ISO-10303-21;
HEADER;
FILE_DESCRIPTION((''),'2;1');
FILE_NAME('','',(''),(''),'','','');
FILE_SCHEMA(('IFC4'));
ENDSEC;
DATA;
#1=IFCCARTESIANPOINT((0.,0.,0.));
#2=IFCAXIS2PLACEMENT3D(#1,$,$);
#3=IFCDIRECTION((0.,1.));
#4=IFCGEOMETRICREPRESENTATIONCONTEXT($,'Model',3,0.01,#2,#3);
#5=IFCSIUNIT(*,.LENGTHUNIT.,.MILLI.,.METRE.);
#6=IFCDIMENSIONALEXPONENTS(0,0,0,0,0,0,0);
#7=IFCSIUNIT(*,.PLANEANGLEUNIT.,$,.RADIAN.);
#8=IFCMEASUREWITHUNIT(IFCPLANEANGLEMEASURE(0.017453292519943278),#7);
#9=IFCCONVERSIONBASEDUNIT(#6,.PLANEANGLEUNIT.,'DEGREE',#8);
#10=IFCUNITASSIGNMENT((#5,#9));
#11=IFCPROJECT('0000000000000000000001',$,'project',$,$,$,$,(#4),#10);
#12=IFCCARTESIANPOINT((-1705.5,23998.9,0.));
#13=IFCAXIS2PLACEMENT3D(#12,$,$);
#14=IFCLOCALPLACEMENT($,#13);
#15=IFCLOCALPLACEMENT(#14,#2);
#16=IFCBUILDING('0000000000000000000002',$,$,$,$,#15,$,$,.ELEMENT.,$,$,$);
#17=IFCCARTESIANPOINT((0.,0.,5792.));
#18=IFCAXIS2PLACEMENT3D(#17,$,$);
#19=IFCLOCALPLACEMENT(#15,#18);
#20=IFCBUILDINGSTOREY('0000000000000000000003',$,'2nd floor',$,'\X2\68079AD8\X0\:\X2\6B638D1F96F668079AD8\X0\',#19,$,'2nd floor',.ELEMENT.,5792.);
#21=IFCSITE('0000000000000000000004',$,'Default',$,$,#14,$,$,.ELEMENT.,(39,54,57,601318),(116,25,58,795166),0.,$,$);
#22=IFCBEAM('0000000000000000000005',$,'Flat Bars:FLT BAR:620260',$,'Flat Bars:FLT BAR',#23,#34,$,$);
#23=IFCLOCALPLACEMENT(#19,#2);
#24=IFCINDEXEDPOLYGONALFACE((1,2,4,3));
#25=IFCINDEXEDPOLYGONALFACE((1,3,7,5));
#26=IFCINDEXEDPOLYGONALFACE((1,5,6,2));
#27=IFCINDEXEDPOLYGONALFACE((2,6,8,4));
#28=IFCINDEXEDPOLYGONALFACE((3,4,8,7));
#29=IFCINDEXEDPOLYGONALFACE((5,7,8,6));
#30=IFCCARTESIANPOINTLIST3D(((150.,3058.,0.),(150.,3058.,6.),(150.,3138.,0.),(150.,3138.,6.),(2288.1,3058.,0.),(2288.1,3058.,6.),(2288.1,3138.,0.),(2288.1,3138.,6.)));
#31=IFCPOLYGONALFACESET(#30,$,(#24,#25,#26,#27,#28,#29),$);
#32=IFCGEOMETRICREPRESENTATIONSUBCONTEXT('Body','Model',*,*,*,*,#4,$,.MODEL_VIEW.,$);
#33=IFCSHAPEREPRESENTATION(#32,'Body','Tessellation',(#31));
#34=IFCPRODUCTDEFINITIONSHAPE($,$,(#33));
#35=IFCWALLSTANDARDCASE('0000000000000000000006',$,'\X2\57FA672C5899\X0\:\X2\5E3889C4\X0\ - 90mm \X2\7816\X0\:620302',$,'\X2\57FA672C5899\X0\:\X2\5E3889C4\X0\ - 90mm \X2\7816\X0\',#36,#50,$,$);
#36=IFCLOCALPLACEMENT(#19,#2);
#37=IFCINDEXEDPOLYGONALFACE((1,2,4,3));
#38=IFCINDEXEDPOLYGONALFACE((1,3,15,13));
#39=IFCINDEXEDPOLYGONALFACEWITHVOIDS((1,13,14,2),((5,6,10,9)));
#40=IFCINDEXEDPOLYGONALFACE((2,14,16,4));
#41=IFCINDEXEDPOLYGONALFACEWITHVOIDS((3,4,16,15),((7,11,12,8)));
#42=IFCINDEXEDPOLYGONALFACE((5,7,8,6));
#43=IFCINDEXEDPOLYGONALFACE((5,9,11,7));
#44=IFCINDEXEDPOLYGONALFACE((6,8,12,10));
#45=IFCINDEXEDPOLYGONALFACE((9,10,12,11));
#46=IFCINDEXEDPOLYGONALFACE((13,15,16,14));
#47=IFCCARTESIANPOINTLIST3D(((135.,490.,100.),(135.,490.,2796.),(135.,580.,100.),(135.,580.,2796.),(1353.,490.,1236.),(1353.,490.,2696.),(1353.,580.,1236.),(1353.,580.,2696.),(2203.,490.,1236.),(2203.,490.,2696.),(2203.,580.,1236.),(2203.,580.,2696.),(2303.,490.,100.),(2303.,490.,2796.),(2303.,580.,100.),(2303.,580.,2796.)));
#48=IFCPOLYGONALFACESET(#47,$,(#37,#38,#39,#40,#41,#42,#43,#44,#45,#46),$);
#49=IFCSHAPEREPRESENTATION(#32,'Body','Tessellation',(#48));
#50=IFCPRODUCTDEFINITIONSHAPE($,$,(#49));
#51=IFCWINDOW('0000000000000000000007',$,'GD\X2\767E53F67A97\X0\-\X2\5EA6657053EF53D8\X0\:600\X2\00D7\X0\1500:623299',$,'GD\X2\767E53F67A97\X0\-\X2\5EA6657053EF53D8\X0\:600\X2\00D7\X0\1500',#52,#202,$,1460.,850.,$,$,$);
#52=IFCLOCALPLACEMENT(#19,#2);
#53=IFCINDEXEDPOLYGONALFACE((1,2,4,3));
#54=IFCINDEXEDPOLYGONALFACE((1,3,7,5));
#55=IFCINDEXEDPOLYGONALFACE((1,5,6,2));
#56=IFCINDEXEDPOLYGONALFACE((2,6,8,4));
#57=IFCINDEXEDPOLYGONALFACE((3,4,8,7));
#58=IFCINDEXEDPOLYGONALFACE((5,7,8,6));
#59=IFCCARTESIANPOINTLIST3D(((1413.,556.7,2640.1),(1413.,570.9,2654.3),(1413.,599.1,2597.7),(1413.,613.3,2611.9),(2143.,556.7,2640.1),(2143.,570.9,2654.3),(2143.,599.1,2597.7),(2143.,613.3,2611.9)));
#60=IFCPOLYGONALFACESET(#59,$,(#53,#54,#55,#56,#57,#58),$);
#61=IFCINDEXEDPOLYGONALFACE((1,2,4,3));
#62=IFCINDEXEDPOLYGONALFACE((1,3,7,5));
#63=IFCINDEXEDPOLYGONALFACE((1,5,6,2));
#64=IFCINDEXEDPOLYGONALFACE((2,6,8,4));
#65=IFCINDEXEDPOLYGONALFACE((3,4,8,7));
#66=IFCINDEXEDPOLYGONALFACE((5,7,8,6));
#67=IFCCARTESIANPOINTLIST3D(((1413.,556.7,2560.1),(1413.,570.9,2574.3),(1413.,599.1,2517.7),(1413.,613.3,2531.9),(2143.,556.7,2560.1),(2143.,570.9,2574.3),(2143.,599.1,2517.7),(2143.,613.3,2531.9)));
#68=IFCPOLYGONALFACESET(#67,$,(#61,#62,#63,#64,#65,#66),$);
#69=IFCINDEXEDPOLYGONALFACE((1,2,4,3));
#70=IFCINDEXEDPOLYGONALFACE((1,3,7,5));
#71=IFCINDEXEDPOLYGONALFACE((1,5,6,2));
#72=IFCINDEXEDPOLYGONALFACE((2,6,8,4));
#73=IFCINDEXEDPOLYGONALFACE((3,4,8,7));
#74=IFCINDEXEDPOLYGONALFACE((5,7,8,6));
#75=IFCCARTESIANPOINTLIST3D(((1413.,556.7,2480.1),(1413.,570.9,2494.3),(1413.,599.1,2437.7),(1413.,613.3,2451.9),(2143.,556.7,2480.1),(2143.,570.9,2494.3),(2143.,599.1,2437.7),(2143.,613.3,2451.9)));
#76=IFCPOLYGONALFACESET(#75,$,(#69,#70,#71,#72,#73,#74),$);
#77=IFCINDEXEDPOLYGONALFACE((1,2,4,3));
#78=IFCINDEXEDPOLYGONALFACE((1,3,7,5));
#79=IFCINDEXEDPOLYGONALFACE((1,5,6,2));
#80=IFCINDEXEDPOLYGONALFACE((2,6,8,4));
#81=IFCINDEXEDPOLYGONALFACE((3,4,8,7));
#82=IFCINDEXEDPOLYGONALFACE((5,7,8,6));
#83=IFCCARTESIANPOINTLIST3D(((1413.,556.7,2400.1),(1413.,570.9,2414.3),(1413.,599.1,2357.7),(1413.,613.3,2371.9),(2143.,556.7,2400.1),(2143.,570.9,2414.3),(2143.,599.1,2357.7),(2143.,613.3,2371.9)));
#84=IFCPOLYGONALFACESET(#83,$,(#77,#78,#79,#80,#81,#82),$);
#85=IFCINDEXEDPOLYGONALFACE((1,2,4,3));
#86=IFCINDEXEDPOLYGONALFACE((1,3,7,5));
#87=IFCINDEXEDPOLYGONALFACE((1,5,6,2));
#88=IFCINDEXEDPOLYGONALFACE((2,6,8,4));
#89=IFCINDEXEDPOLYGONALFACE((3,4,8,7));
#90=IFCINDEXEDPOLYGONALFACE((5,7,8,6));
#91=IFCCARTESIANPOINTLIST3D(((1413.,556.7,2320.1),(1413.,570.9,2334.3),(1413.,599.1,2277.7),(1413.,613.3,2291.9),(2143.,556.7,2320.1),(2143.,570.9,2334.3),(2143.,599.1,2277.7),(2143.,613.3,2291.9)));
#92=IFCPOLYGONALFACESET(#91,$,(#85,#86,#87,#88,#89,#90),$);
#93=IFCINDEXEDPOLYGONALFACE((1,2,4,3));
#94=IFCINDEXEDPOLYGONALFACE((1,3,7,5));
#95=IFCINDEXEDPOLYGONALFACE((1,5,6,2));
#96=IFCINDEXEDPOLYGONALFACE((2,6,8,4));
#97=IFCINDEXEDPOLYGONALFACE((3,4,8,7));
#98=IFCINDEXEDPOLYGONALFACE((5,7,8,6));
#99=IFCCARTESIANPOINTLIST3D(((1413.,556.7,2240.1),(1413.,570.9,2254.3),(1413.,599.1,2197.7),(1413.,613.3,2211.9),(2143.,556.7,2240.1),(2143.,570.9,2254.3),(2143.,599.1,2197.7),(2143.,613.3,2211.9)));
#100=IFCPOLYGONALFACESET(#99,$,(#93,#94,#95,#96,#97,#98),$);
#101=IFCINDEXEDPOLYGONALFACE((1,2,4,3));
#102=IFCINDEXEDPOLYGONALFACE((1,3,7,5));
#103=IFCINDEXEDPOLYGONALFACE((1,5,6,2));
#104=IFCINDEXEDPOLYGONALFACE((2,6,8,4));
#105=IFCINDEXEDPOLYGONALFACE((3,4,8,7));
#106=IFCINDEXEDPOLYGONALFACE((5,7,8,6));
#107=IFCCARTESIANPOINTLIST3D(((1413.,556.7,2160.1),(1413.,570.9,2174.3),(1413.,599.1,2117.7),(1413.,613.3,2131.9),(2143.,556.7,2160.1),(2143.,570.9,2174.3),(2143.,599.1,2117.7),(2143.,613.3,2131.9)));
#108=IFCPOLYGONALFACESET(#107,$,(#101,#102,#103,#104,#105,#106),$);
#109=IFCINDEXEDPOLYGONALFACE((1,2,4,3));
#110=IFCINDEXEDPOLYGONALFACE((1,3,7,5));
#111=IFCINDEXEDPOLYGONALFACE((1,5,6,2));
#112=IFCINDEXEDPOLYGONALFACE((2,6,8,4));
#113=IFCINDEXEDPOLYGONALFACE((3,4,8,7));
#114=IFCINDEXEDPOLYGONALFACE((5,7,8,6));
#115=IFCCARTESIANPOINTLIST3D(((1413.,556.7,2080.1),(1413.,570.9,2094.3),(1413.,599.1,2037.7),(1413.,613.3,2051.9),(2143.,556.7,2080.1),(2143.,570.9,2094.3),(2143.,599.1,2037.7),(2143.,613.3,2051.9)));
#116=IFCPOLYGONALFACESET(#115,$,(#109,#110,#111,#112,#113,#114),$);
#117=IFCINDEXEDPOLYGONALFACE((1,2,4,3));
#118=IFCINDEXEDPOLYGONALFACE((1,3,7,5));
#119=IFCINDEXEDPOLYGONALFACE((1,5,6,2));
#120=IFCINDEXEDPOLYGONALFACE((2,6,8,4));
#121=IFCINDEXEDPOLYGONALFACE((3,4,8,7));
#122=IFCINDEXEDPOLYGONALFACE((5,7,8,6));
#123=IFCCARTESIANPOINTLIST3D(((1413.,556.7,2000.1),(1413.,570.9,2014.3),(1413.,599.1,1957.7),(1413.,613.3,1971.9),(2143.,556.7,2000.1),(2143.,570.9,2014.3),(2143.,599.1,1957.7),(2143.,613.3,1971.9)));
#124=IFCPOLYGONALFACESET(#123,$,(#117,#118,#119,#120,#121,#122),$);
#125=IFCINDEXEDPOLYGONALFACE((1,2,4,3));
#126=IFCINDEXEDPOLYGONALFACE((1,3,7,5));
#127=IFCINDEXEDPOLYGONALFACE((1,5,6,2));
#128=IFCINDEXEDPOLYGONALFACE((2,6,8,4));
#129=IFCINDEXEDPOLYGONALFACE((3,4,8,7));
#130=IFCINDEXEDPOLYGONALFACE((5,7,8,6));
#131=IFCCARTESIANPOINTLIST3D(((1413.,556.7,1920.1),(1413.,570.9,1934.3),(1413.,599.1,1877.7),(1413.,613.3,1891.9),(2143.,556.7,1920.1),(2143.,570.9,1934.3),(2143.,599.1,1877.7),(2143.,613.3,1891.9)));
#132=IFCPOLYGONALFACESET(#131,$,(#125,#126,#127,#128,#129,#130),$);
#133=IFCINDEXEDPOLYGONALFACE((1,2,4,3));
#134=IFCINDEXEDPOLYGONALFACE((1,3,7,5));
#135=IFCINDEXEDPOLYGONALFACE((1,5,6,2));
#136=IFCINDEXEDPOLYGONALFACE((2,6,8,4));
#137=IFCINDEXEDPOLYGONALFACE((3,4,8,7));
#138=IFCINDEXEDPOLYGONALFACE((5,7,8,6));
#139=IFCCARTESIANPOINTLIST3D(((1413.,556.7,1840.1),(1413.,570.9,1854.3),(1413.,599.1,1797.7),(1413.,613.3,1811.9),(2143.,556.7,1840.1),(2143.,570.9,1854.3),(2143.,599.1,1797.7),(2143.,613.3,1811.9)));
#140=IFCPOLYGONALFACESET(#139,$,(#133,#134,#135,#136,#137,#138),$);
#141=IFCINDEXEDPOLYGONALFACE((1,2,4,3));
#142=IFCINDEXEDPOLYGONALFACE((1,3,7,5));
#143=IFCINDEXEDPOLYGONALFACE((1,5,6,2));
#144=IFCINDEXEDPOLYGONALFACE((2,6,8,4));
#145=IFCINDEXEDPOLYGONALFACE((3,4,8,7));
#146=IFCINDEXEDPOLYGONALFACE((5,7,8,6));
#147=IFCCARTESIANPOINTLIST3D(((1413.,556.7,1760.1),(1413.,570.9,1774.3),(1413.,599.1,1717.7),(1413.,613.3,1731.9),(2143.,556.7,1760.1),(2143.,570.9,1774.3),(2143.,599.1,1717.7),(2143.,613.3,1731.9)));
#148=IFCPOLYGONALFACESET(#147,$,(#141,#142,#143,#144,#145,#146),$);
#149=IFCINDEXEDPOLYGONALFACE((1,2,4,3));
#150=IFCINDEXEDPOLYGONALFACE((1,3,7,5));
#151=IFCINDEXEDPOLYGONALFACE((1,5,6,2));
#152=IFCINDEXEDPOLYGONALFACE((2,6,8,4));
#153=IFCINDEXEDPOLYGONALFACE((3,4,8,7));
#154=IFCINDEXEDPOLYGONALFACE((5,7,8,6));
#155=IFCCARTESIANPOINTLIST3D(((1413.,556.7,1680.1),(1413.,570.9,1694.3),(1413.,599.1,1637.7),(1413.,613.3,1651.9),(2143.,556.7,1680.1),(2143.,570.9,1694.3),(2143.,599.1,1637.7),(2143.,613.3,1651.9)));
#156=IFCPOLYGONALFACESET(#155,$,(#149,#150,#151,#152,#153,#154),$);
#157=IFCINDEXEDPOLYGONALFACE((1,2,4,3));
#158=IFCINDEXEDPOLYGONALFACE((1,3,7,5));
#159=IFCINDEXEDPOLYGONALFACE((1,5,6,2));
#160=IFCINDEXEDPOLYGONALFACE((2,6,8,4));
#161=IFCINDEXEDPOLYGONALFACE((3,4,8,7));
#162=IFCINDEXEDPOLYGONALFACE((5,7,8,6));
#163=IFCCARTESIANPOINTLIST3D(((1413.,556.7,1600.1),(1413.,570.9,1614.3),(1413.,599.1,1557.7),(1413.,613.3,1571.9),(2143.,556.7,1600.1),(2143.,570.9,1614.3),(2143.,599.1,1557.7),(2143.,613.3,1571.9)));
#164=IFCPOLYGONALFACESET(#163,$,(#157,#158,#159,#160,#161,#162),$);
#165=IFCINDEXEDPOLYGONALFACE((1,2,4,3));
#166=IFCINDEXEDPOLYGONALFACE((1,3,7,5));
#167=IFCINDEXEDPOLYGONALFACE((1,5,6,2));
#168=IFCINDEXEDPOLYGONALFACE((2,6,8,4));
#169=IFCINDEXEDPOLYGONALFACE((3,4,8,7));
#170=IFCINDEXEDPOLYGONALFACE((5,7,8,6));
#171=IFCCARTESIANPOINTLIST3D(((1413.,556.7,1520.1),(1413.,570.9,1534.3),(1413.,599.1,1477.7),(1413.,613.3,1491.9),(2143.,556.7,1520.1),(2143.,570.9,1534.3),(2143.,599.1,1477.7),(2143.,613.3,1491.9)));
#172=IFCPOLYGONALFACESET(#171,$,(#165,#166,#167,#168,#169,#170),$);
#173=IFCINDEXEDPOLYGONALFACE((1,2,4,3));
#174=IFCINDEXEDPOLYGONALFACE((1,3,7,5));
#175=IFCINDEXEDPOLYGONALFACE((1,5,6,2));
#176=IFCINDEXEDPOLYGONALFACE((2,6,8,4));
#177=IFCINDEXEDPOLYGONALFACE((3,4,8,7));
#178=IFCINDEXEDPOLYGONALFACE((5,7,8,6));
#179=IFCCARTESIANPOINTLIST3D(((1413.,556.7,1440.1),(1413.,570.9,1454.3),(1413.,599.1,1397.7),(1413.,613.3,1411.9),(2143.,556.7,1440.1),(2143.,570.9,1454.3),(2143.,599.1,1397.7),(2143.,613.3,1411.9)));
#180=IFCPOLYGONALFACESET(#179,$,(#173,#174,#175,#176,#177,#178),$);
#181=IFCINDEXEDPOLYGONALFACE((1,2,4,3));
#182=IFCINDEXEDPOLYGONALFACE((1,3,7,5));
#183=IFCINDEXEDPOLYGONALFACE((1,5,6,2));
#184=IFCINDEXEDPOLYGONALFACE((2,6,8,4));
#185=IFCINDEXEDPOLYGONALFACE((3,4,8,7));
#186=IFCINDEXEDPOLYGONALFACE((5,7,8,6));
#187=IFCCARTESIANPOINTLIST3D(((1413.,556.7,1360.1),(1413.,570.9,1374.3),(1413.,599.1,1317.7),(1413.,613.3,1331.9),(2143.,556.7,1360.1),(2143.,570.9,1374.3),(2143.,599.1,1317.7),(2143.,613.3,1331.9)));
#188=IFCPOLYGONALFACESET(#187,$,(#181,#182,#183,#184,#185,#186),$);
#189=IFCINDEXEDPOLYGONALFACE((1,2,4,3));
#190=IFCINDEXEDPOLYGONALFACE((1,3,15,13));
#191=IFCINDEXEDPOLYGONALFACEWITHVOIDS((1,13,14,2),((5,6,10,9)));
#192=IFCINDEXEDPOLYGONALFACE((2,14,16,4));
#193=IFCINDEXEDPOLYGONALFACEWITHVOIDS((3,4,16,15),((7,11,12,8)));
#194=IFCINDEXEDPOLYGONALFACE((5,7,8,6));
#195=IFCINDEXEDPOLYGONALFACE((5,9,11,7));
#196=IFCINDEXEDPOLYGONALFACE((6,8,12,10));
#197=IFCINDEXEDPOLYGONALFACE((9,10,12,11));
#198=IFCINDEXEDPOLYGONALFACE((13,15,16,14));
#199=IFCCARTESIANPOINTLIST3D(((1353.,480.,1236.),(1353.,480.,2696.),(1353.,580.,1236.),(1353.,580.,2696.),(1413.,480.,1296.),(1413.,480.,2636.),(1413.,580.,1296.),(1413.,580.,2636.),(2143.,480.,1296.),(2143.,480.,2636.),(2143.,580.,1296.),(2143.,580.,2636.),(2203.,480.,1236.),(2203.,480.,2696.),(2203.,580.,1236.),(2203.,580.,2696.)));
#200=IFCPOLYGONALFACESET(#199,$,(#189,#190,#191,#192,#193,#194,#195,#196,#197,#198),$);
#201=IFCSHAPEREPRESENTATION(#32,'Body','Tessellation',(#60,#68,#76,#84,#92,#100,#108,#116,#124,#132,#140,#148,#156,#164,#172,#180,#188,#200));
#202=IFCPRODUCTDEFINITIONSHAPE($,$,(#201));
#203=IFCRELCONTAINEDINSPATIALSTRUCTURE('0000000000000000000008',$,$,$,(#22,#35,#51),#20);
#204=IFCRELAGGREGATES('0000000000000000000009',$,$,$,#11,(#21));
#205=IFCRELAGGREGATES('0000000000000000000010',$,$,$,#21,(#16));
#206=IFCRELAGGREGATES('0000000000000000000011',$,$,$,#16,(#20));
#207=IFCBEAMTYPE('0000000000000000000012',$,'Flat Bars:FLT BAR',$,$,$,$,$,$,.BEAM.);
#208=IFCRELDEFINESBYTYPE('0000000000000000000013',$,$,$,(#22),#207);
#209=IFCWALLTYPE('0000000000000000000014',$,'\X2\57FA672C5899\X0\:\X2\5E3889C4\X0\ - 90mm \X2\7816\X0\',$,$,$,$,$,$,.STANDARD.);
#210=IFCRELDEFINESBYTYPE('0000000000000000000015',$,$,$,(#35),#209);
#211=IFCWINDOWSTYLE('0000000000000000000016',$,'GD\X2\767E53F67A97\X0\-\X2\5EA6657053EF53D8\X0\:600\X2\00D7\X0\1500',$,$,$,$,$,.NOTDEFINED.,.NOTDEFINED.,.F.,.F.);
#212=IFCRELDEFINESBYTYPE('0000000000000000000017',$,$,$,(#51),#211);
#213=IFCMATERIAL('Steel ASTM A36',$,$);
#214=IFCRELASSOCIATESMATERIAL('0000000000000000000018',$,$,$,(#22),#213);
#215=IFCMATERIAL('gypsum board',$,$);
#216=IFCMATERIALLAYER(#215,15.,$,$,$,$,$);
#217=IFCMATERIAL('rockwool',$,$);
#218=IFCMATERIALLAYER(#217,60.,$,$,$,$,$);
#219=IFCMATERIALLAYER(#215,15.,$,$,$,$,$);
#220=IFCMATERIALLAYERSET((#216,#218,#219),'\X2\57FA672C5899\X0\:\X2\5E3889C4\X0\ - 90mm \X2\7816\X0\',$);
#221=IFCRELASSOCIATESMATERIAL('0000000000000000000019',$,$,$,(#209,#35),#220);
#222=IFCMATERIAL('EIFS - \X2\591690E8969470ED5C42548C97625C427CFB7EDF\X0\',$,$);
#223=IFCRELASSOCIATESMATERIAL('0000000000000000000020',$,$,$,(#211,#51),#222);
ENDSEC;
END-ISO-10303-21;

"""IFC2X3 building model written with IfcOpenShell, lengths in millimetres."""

from ifc_helpers import new_model, entity, si_unit, converted_unit, direction, frame, frame_2d, origin, origin_2d_with_axis, place, context, subcontext, project, spatial, polyline, rectangle, outline, extrude, source, transform, mapped, material, layer, layer_set, layer_usage, type_object, type_shapes, element, fill, save


model = new_model("IFC2X3")

# Units and contexts
model_context = context("Model", 3, precision=0.01, world=origin(), true_north=direction((0.0, 1.0)))
body_context = subcontext(model_context, "Body", "Model", "MODEL_VIEW")
ifc_project = project(units=[si_unit("LENGTHUNIT", "METRE", prefix="MILLI"), converted_unit("PLANEANGLEUNIT", "DEGREE", entity("IfcPlaneAngleMeasure", 0.017453292519943278), si_unit("PLANEANGLEUNIT", "RADIAN"), dimensions=[0, 0, 0, 0, 0, 0, 0])], contexts=[model_context])

# Site, building, storey
site_placement = place(None, frame((-1705.5, 23998.9, 0.0)))
site = spatial("IfcSite", under=ifc_project, at=site_placement, Name="Default", CompositionType="ELEMENT", RefLatitude=(39, 54, 57, 601318), RefLongitude=(116, 25, 58, 795166), RefElevation=0.0)
building_placement = place(site_placement, origin())
building = spatial("IfcBuilding", under=site, at=building_placement, CompositionType="ELEMENT")
storey_placement = place(building_placement, frame((0.0, 0.0, 5792.0)))
storey = spatial("IfcBuildingStorey", under=building, at=storey_placement, Name="2nd floor", ObjectType="标高:正负零标高", LongName="2nd floor", CompositionType="ELEMENT", Elevation=5792.0)

# Beam
ifc_material_1 = material(Name="Steel ASTM A36")
beam_type_1 = type_object("IfcBeamType", Name="Flat Bars:FLT BAR", PredefinedType="BEAM")
beam_1_placement = place(storey_placement, frame((150.0, 3098.0, 6.0)))
element("IfcBeam", 1, at=beam_1_placement, inside=storey, type_object=beam_type_1, material=ifc_material_1, Name="Flat Bars:FLT BAR:620260", ObjectType="Flat Bars:FLT BAR", context=body_context, shape_type="SweptSolid", body=[
    extrude(rectangle(XDim=6.0, YDim=80.0, at=origin_2d_with_axis()), frame((0.0, 0.0, -3.0), z_axis=(1.0, 0.0, 0.0), x_axis=(0.0, 0.0, -1.0)), (0.0, 0.0, 1.0), 2138.1),
])

# Wall, opening, window
ifc_material_2 = material(Name="gypsum board")
ifc_layer_1 = layer(ifc_material_2, 15.0)
ifc_material_3 = material(Name="rockwool")
ifc_layer_2 = layer(ifc_material_3, 60.0)
ifc_layer_3 = layer(ifc_material_2, 15.0)
ifc_layer_set = layer_set([ifc_layer_1, ifc_layer_2, ifc_layer_3], Name="基本墙:常规 - 90mm 砖")
ifc_layer_usage = layer_usage(ifc_layer_set, "AXIS2", "NEGATIVE", 45.0)
wall_type = type_object("IfcWallType", Name="基本墙:常规 - 90mm 砖", PredefinedType="STANDARD", material=ifc_layer_set)
wall_placement = place(storey_placement, frame((2303.0, 535.0, 100.0), z_axis=(0.0, 0.0, 1.0), x_axis=(-1.0, 0.0, 0.0)))
wall = element("IfcWallStandardCase", 2, at=wall_placement, inside=storey, type_object=wall_type, material=ifc_layer_usage, Name="基本墙:常规 - 90mm 砖:620302", ObjectType="基本墙:常规 - 90mm 砖", context=body_context, shape_type="SweptSolid", body=[
    extrude(rectangle(XDim=2168.0, YDim=90.0, at=frame_2d((1084.0, 0.0), x_axis=(-1.0, 0.0))), origin(), (0.0, 0.0, 1.0), 2696.0),
])
opening_1_placement = place(wall_placement, frame((950.0, 45.0, 1136.0)))
opening_1 = element("IfcOpeningElement", 3, at=opening_1_placement, cuts=wall, ObjectType="Opening", context=body_context, shape_type="SweptSolid", body=[
    extrude(rectangle(XDim=1460.0, YDim=850.0, at=frame_2d((730.0, 425.0), x_axis=(1.0, 0.0))), frame((0.0, 0.0, 0.0), z_axis=(0.0, -1.0, 0.0), x_axis=(0.0, 0.0, 1.0)), (0.0, 0.0, 1.0), 90.0),
])
ifc_material_4 = material(Name="EIFS - 外部隔热层和面层系统")
window_style = type_object("IfcWindowStyle", Name="GD百叶窗-度数可变:600×1500", ConstructionType="NOTDEFINED", OperationType="NOTDEFINED", ParameterTakesPrecedence=False, Sizeable=False, material=ifc_material_4)
shared_shape = source(origin(), body_context, "Body", "SweptSolid", [
    extrude(rectangle(XDim=60.0, YDim=20.0, at=frame_2d((0.0, 0.0), x_axis=(0.0, 1.0))), frame((790.0, 295.0, 1390.0), z_axis=(-1.0, 0.0, 0.0), x_axis=(0.0, -0.707107, -0.707107)), (0.0, 0.0, 1.0), 730.0),
    extrude(rectangle(XDim=60.0, YDim=20.0, at=frame_2d((0.0, 0.0), x_axis=(0.0, 1.0))), frame((790.0, 295.0, 1310.0), z_axis=(-1.0, 0.0, 0.0), x_axis=(0.0, -0.707107, -0.707107)), (0.0, 0.0, 1.0), 730.0),
    extrude(rectangle(XDim=60.0, YDim=20.0, at=frame_2d((0.0, 0.0), x_axis=(0.0, 1.0))), frame((790.0, 295.0, 1230.0), z_axis=(-1.0, 0.0, 0.0), x_axis=(0.0, -0.707107, -0.707107)), (0.0, 0.0, 1.0), 730.0),
    extrude(rectangle(XDim=60.0, YDim=20.0, at=frame_2d((0.0, 0.0), x_axis=(0.0, 1.0))), frame((790.0, 295.0, 1150.0), z_axis=(-1.0, 0.0, 0.0), x_axis=(0.0, -0.707107, -0.707107)), (0.0, 0.0, 1.0), 730.0),
    extrude(rectangle(XDim=60.0, YDim=20.0, at=frame_2d((0.0, 0.0), x_axis=(0.0, 1.0))), frame((790.0, 295.0, 1070.0), z_axis=(-1.0, 0.0, 0.0), x_axis=(0.0, -0.707107, -0.707107)), (0.0, 0.0, 1.0), 730.0),
    extrude(rectangle(XDim=60.0, YDim=20.0, at=frame_2d((0.0, 0.0), x_axis=(0.0, 1.0))), frame((790.0, 295.0, 990.0), z_axis=(-1.0, 0.0, 0.0), x_axis=(0.0, -0.707107, -0.707107)), (0.0, 0.0, 1.0), 730.0),
    extrude(rectangle(XDim=60.0, YDim=20.0, at=frame_2d((0.0, 0.0), x_axis=(0.0, 1.0))), frame((790.0, 295.0, 910.0), z_axis=(-1.0, 0.0, 0.0), x_axis=(0.0, -0.707107, -0.707107)), (0.0, 0.0, 1.0), 730.0),
    extrude(rectangle(XDim=60.0, YDim=20.0, at=frame_2d((0.0, 0.0), x_axis=(0.0, 1.0))), frame((790.0, 295.0, 830.0), z_axis=(-1.0, 0.0, 0.0), x_axis=(0.0, -0.707107, -0.707107)), (0.0, 0.0, 1.0), 730.0),
    extrude(rectangle(XDim=60.0, YDim=20.0, at=frame_2d((0.0, 0.0), x_axis=(0.0, 1.0))), frame((790.0, 295.0, 750.0), z_axis=(-1.0, 0.0, 0.0), x_axis=(0.0, -0.707107, -0.707107)), (0.0, 0.0, 1.0), 730.0),
    extrude(rectangle(XDim=60.0, YDim=20.0, at=frame_2d((0.0, 0.0), x_axis=(0.0, 1.0))), frame((790.0, 295.0, 670.0), z_axis=(-1.0, 0.0, 0.0), x_axis=(0.0, -0.707107, -0.707107)), (0.0, 0.0, 1.0), 730.0),
    extrude(rectangle(XDim=60.0, YDim=20.0, at=frame_2d((0.0, 0.0), x_axis=(0.0, 1.0))), frame((790.0, 295.0, 590.0), z_axis=(-1.0, 0.0, 0.0), x_axis=(0.0, -0.707107, -0.707107)), (0.0, 0.0, 1.0), 730.0),
    extrude(rectangle(XDim=60.0, YDim=20.0, at=frame_2d((0.0, 0.0), x_axis=(0.0, 1.0))), frame((790.0, 295.0, 510.0), z_axis=(-1.0, 0.0, 0.0), x_axis=(0.0, -0.707107, -0.707107)), (0.0, 0.0, 1.0), 730.0),
    extrude(rectangle(XDim=60.0, YDim=20.0, at=frame_2d((0.0, 0.0), x_axis=(0.0, 1.0))), frame((790.0, 295.0, 430.0), z_axis=(-1.0, 0.0, 0.0), x_axis=(0.0, -0.707107, -0.707107)), (0.0, 0.0, 1.0), 730.0),
    extrude(rectangle(XDim=60.0, YDim=20.0, at=frame_2d((0.0, 0.0), x_axis=(0.0, 1.0))), frame((790.0, 295.0, 350.0), z_axis=(-1.0, 0.0, 0.0), x_axis=(0.0, -0.707107, -0.707107)), (0.0, 0.0, 1.0), 730.0),
    extrude(rectangle(XDim=60.0, YDim=20.0, at=frame_2d((0.0, 0.0), x_axis=(0.0, 1.0))), frame((790.0, 295.0, 270.0), z_axis=(-1.0, 0.0, 0.0), x_axis=(0.0, -0.707107, -0.707107)), (0.0, 0.0, 1.0), 730.0),
    extrude(rectangle(XDim=60.0, YDim=20.0, at=frame_2d((0.0, 0.0), x_axis=(0.0, 1.0))), frame((790.0, 295.0, 190.0), z_axis=(-1.0, 0.0, 0.0), x_axis=(0.0, -0.707107, -0.707107)), (0.0, 0.0, 1.0), 730.0),
    extrude(rectangle(XDim=60.0, YDim=20.0, at=frame_2d((0.0, 0.0), x_axis=(0.0, 1.0))), frame((790.0, 295.0, 110.0), z_axis=(-1.0, 0.0, 0.0), x_axis=(0.0, -0.707107, -0.707107)), (0.0, 0.0, 1.0), 730.0),
    extrude(outline(polyline([(-425.0, -730.0), (425.0, -730.0), (425.0, 730.0), (-425.0, 730.0), (-425.0, -730.0)]), holes=[polyline([(365.0, -670.0), (-365.0, -670.0), (-365.0, 670.0), (365.0, 670.0), (365.0, -670.0)])]), frame((425.0, 290.0, 730.0), z_axis=(0.0, -1.0, 0.0), x_axis=(-1.0, 0.0, 0.0)), (0.0, 0.0, 1.0), 100.0),
])
type_shapes(window_style, [shared_shape])
window_placement = place(opening_1_placement, frame((0.0, 200.0, 0.0), z_axis=(0.0, 0.0, 1.0), x_axis=(-1.0, 0.0, 0.0)))
window = element("IfcWindow", 4, at=window_placement, inside=storey, type_object=window_style, material=ifc_material_4, Name="GD百叶窗-度数可变:600×1500:623299", ObjectType="GD百叶窗-度数可变:600×1500", OverallHeight=1460.0, OverallWidth=850.0, context=body_context, shape_type="MappedRepresentation", body=[
    mapped(shared_shape, transform((0.0, 0.0, 0.0), scale=1.0)),
])
fill(opening_1, window)

save(model, "model.ifc")
